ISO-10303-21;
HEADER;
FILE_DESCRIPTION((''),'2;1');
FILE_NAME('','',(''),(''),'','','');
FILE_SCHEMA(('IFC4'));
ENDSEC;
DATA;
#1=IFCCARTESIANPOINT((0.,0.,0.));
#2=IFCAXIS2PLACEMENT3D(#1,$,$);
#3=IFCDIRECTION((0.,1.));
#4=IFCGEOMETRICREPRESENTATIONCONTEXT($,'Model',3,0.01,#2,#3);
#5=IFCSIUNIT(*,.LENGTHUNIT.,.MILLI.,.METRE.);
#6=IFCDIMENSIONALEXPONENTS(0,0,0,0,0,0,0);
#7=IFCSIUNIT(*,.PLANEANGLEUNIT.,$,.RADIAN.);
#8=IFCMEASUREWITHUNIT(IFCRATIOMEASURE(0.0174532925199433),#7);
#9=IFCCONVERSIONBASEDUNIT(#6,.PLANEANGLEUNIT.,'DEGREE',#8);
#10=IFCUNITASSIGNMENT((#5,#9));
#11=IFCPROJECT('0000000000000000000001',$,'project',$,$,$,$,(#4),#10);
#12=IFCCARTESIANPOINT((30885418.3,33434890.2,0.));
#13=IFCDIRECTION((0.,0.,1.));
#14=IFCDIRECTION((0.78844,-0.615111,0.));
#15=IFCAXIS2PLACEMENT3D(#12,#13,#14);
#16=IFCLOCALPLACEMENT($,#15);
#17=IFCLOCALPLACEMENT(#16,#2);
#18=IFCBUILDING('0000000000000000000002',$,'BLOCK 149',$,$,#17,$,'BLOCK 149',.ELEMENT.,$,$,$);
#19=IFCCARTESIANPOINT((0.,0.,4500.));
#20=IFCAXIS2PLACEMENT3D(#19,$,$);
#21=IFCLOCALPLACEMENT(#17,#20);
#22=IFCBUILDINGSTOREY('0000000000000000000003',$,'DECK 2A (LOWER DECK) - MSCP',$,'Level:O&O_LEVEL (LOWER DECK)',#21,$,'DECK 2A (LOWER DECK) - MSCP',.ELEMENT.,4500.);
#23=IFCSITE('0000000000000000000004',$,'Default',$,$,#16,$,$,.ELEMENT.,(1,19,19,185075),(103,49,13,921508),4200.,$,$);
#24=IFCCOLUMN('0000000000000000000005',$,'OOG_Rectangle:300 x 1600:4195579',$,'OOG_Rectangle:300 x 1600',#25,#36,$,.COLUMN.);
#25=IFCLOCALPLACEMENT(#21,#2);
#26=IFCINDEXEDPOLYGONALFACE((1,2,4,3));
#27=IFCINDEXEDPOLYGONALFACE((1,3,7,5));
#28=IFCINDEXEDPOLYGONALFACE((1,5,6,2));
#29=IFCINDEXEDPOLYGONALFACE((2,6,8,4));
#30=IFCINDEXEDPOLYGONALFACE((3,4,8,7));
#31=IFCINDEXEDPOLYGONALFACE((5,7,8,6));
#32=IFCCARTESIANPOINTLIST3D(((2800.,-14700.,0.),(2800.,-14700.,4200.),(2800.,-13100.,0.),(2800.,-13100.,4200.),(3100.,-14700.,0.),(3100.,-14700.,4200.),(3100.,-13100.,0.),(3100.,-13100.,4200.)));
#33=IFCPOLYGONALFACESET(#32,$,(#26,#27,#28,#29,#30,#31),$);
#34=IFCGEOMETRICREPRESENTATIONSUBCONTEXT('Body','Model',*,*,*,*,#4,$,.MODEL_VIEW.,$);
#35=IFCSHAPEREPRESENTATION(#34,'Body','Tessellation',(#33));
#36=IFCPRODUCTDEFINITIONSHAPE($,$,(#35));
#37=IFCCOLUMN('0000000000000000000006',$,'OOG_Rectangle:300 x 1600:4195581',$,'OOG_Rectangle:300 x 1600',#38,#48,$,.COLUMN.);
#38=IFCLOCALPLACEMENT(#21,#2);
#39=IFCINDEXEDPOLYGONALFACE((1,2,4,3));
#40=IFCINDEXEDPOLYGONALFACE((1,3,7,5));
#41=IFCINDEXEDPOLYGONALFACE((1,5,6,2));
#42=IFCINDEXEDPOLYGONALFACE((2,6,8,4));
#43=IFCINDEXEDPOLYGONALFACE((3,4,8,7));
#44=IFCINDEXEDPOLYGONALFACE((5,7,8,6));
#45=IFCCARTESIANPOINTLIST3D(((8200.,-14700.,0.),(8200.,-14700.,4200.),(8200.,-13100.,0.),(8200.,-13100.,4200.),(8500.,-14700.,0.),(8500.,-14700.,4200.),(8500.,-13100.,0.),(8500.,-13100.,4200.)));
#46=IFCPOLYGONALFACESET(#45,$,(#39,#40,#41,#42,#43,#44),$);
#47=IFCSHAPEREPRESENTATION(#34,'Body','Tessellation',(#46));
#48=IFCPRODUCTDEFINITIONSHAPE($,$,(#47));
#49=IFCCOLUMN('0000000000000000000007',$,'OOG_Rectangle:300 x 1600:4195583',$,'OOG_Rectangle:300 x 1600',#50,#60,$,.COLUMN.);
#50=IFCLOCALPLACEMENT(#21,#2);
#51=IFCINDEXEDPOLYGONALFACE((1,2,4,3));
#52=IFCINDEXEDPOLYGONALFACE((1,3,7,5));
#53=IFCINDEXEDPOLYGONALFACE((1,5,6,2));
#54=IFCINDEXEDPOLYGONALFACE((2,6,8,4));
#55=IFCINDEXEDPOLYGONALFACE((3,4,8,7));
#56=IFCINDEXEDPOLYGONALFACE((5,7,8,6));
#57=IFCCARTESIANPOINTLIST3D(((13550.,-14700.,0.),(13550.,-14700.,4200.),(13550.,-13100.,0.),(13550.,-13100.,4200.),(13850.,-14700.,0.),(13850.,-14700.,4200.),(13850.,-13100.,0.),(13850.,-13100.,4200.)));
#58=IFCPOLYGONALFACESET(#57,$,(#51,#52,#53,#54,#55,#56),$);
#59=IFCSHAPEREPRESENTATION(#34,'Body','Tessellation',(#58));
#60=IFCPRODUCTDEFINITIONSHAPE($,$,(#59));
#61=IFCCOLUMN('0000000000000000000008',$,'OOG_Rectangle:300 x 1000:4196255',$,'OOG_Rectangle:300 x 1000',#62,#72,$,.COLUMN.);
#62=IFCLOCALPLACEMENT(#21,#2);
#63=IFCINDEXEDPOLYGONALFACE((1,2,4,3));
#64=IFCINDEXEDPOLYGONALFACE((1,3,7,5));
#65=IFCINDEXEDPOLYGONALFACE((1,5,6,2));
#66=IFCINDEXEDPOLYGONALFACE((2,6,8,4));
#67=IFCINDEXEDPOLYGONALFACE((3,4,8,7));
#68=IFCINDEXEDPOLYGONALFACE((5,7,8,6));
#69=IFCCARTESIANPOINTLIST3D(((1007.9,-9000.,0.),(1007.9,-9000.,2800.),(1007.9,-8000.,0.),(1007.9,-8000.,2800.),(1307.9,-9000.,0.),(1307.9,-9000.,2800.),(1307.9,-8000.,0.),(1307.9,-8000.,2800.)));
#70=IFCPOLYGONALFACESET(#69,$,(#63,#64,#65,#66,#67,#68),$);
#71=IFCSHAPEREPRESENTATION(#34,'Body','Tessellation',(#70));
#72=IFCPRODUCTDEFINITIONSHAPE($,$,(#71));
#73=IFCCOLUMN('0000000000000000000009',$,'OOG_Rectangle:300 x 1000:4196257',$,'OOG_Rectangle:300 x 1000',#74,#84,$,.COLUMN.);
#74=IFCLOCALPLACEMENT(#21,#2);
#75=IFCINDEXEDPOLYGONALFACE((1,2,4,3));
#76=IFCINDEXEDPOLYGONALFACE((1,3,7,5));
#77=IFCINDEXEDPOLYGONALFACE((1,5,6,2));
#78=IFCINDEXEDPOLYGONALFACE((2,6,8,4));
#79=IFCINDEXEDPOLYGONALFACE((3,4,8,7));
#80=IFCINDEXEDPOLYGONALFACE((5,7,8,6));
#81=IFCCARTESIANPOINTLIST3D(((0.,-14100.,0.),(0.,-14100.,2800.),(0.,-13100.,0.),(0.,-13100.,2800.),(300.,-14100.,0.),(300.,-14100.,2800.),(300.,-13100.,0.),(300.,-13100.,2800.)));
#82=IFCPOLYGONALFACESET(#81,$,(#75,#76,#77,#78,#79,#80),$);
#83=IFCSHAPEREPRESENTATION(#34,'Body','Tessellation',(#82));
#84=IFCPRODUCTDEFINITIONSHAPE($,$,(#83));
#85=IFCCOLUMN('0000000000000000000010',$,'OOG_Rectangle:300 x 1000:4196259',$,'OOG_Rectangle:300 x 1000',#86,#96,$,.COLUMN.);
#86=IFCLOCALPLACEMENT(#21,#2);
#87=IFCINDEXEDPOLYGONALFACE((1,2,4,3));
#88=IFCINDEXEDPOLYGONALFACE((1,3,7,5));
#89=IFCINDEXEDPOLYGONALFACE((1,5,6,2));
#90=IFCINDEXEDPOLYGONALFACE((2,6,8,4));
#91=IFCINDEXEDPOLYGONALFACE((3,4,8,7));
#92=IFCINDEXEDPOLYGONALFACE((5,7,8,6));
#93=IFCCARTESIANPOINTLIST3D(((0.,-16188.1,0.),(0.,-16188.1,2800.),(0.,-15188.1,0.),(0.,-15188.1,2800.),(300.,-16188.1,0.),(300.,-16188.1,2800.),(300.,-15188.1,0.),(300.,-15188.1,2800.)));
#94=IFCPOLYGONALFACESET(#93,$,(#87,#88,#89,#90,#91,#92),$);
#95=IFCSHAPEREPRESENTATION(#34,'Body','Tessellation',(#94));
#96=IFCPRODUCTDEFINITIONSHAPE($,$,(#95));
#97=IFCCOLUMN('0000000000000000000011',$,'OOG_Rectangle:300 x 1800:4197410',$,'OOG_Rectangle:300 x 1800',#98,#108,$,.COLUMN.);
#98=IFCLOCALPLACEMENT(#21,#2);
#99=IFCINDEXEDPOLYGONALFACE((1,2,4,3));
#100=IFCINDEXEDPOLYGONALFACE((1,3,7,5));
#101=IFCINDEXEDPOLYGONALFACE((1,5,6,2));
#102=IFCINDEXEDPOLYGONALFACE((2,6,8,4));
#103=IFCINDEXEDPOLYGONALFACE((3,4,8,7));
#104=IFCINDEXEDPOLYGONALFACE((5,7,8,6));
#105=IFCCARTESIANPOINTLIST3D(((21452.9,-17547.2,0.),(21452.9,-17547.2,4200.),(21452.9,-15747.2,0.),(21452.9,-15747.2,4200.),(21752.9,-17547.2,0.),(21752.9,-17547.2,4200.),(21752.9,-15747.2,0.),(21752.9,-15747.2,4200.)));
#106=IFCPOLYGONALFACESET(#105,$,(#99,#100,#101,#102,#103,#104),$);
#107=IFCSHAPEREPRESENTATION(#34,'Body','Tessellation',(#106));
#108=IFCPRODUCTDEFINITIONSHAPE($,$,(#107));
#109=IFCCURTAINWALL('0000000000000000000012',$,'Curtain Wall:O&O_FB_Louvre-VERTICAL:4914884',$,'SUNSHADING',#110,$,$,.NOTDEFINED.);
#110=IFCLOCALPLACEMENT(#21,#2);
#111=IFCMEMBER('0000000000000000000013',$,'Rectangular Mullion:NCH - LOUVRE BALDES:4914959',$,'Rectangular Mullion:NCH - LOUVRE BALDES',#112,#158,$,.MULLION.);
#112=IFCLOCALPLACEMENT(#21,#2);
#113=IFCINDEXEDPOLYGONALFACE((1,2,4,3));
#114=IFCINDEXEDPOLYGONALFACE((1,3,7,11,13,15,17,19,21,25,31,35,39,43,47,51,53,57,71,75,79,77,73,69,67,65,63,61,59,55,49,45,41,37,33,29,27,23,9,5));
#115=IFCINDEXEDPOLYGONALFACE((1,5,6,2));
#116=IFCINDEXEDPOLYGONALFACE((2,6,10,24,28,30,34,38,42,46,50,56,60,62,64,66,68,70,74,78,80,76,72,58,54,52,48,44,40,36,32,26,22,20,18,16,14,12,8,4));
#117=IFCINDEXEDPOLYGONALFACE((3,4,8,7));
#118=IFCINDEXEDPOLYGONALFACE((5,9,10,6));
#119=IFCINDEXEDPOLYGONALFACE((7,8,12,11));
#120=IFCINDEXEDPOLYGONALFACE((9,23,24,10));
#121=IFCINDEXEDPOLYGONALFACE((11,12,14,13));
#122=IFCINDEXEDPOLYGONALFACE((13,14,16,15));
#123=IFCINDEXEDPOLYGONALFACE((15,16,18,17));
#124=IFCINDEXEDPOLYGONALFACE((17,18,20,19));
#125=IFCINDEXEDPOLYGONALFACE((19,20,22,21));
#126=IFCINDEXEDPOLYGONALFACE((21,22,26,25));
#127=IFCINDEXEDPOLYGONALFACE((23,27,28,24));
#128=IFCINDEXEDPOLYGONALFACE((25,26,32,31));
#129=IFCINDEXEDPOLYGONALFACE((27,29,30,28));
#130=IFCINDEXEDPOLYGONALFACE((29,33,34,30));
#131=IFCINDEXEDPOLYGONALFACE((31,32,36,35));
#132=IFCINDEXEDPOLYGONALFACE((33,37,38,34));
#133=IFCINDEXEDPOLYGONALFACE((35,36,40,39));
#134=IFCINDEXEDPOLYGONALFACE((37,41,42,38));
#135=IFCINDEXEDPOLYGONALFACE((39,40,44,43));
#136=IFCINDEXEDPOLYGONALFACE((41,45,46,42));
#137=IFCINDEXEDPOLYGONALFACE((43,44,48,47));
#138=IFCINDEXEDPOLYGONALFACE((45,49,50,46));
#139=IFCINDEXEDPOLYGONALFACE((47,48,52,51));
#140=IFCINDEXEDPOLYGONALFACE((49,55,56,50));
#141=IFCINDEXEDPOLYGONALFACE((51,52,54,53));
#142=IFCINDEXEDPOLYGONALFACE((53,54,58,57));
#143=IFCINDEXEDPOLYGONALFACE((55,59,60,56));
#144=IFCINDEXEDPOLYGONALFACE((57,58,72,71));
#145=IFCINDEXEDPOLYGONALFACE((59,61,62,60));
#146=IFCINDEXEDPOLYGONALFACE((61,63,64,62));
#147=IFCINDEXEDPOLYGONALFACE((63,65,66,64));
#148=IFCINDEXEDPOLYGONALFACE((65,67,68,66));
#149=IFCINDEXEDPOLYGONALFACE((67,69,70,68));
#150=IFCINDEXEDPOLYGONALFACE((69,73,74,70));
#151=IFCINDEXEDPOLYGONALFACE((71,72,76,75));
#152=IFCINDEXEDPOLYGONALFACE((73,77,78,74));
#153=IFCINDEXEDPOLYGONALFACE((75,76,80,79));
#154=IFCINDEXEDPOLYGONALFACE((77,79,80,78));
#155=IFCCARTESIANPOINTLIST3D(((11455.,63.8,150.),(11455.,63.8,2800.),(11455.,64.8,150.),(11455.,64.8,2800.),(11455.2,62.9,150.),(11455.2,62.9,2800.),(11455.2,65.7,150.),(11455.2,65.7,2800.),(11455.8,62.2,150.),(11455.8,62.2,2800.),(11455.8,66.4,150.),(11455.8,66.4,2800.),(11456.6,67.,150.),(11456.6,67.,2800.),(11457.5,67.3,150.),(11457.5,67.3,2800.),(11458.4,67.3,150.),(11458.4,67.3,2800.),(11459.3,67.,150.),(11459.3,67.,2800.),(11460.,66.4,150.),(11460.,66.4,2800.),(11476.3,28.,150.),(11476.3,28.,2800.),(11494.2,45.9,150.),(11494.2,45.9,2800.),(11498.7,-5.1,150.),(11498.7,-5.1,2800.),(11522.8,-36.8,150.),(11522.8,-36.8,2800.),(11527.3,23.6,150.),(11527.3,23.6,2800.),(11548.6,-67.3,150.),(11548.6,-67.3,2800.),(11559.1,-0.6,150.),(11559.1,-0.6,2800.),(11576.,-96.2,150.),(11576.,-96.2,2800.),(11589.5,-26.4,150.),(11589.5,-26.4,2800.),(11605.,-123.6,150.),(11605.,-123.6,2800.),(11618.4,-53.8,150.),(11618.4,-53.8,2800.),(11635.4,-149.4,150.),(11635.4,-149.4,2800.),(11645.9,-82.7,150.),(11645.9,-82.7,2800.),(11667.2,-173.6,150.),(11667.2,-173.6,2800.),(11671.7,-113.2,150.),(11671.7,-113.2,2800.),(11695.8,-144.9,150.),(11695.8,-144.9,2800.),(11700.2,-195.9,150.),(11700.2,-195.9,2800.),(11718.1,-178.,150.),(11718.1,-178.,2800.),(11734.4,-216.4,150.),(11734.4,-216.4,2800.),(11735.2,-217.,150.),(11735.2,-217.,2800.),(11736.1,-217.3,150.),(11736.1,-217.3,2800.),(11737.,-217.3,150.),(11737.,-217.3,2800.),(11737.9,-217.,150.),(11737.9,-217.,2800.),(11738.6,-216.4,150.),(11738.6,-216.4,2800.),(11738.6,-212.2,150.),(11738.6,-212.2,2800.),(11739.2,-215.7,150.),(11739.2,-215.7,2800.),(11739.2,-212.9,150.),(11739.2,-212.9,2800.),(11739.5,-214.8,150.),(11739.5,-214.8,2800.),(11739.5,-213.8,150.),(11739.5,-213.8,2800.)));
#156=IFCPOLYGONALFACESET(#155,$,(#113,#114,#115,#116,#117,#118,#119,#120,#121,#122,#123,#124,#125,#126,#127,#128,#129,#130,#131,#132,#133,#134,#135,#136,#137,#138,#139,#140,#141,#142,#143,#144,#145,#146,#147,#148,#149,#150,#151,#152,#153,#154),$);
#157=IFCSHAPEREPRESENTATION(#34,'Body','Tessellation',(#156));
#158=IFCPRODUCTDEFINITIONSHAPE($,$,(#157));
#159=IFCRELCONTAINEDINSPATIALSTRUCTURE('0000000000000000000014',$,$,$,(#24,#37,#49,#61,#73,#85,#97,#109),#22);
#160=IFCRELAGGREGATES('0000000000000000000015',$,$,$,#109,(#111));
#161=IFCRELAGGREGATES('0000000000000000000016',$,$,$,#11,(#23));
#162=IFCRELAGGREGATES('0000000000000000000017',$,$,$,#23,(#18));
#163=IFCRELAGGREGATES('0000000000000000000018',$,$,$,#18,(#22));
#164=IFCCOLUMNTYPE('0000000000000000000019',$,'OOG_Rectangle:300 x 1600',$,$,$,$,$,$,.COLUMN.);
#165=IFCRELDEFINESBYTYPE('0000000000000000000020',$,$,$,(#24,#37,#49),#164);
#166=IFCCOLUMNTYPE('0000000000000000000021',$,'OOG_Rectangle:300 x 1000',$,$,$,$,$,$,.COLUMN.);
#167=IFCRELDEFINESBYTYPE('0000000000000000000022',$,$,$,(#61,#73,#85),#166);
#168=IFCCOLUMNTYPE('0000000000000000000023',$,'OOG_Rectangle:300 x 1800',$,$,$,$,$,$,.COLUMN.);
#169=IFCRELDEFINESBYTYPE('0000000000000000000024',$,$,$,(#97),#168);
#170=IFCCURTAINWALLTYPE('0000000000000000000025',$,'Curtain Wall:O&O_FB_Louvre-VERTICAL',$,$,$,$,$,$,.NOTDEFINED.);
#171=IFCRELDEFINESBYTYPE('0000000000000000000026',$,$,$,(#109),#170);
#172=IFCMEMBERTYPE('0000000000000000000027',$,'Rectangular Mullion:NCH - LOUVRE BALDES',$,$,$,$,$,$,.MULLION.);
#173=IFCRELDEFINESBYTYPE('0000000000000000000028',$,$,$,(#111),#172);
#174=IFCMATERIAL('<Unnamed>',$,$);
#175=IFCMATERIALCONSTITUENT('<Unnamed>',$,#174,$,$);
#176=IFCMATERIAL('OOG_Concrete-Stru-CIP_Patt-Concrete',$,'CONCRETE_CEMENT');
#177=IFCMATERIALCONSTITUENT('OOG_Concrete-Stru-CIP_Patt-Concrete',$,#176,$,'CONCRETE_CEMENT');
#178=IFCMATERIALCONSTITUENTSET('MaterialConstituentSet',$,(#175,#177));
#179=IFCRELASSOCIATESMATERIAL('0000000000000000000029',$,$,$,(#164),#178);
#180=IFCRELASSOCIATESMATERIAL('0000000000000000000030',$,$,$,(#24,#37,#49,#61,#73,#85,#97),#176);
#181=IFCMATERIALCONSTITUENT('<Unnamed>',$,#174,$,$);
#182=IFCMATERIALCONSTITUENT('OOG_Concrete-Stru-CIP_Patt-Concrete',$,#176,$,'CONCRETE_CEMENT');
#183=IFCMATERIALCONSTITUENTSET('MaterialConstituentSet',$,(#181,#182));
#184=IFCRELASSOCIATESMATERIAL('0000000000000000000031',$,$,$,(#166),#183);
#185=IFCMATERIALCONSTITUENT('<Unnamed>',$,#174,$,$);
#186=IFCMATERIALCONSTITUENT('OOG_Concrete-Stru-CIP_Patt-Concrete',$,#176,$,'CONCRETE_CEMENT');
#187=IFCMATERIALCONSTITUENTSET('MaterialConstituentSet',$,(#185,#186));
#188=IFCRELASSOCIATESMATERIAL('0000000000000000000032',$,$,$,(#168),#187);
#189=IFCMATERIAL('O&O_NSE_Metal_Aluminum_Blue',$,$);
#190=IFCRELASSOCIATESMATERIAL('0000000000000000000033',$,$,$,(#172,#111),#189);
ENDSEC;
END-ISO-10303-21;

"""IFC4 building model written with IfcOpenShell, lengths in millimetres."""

from ifc_helpers import new_model, entity, si_unit, converted_unit, direction, frame, origin, place, context, subcontext, project, spatial, indexed_curve, outline, extrude, source, transform, mapped, material, constituent, constituent_set, type_object, type_shapes, element, aggregate, save


model = new_model("IFC4")

# Units and contexts
model_context = context("Model", 3, precision=0.01, world=origin(), true_north=direction((0.0, 1.0)))
body_context = subcontext(model_context, "Body", "Model", "MODEL_VIEW")
ifc_project = project(units=[si_unit("LENGTHUNIT", "METRE", prefix="MILLI"), converted_unit("PLANEANGLEUNIT", "DEGREE", entity("IfcRatioMeasure", 0.0174532925199433), si_unit("PLANEANGLEUNIT", "RADIAN"), dimensions=[0, 0, 0, 0, 0, 0, 0])], contexts=[model_context])

# Site, building, storey
site_placement = place(None, frame((30885418.3, 33434890.2, 0.0), z_axis=(0.0, 0.0, 1.0), x_axis=(0.78844, -0.615111, 0.0)))
site = spatial("IfcSite", under=ifc_project, at=site_placement, Name="Default", CompositionType="ELEMENT", RefLatitude=(1, 19, 19, 185075), RefLongitude=(103, 49, 13, 921508), RefElevation=4200.0)
building_placement = place(site_placement, origin())
building = spatial("IfcBuilding", under=site, at=building_placement, Name="BLOCK 149", LongName="BLOCK 149", CompositionType="ELEMENT")
storey_placement = place(building_placement, frame((0.0, 0.0, 4500.0)))
storey = spatial("IfcBuildingStorey", under=building, at=storey_placement, Name="DECK 2A (LOWER DECK) - MSCP", ObjectType="Level:O&O_LEVEL (LOWER DECK)", LongName="DECK 2A (LOWER DECK) - MSCP", CompositionType="ELEMENT", Elevation=4500.0)

# Columns
ifc_material_1 = material(Name="OOG_Concrete-Stru-CIP_Patt-Concrete", Category="CONCRETE_CEMENT")
ifc_material_2 = material(Name="<Unnamed>")
ifc_constituent_1 = constituent(ifc_material_2, Name="<Unnamed>")
ifc_constituent_2 = constituent(ifc_material_1, Name="OOG_Concrete-Stru-CIP_Patt-Concrete", Category="CONCRETE_CEMENT")
ifc_constituent_set_1 = constituent_set(constituents=[ifc_constituent_1, ifc_constituent_2], Name="MaterialConstituentSet")
column_type_1 = type_object("IfcColumnType", Name="OOG_Rectangle:300 x 1600", PredefinedType="COLUMN", material=ifc_constituent_set_1)
shared_shape_1 = source(origin(), body_context, "Body", "SweptSolid", [
    extrude(outline(indexed_curve([(-800.0, -150.0), (800.0, -150.0), (800.0, 150.0), (-800.0, 150.0), (-800.0, -150.0)], self_intersect=False)), frame((0.0, 0.0, 4500.0), z_axis=(0.0, 0.0, 1.0), x_axis=(0.0, -1.0, 0.0)), (0.0, 0.0, 1.0), 4200.0),
])
type_shapes(column_type_1, [shared_shape_1])
for number, where, name in (
    (1, (2950.0, -13900.0, -4500.0), "OOG_Rectangle:300 x 1600:4195579"),
    (2, (8350.0, -13900.0, -4500.0), "OOG_Rectangle:300 x 1600:4195581"),
    (3, (13700.0, -13900.0, -4500.0), "OOG_Rectangle:300 x 1600:4195583"),
):
    element("IfcColumn", number, at=place(storey_placement, frame(where)), inside=storey, type_object=column_type_1, material=ifc_material_1, Name=name, ObjectType="OOG_Rectangle:300 x 1600", PredefinedType="COLUMN", context=body_context, shape_type="MappedRepresentation", body=[
        mapped(shared_shape_1, transform((0.0, 0.0, 0.0), scale=1.0)),
    ])
ifc_constituent_3 = constituent(ifc_material_2, Name="<Unnamed>")
ifc_constituent_4 = constituent(ifc_material_1, Name="OOG_Concrete-Stru-CIP_Patt-Concrete", Category="CONCRETE_CEMENT")
ifc_constituent_set_2 = constituent_set(constituents=[ifc_constituent_3, ifc_constituent_4], Name="MaterialConstituentSet")
column_type_2 = type_object("IfcColumnType", Name="OOG_Rectangle:300 x 1000", PredefinedType="COLUMN", material=ifc_constituent_set_2)
shared_shape_2 = source(origin(), body_context, "Body", "SweptSolid", [
    extrude(outline(indexed_curve([(-500.0, -150.0), (500.0, -150.0), (500.0, 150.0), (-500.0, 150.0), (-500.0, -150.0)], self_intersect=False)), frame((0.0, 0.0, 4500.0), z_axis=(0.0, 0.0, 1.0), x_axis=(0.0, -1.0, 0.0)), (0.0, 0.0, 1.0), 2800.0),
])
type_shapes(column_type_2, [shared_shape_2])
for number, where, name in (
    (4, (1157.9, -8500.0, -4500.0), "OOG_Rectangle:300 x 1000:4196255"),
    (5, (150.0, -13600.0, -4500.0), "OOG_Rectangle:300 x 1000:4196257"),
    (6, (150.0, -15688.1, -4500.0), "OOG_Rectangle:300 x 1000:4196259"),
):
    element("IfcColumn", number, at=place(storey_placement, frame(where)), inside=storey, type_object=column_type_2, material=ifc_material_1, Name=name, ObjectType="OOG_Rectangle:300 x 1000", PredefinedType="COLUMN", context=body_context, shape_type="MappedRepresentation", body=[
        mapped(shared_shape_2, transform((0.0, 0.0, 0.0), scale=1.0)),
    ])
ifc_constituent_5 = constituent(ifc_material_2, Name="<Unnamed>")
ifc_constituent_6 = constituent(ifc_material_1, Name="OOG_Concrete-Stru-CIP_Patt-Concrete", Category="CONCRETE_CEMENT")
ifc_constituent_set_3 = constituent_set(constituents=[ifc_constituent_5, ifc_constituent_6], Name="MaterialConstituentSet")
column_type_3 = type_object("IfcColumnType", Name="OOG_Rectangle:300 x 1800", PredefinedType="COLUMN", material=ifc_constituent_set_3)
shared_shape_3 = source(origin(), body_context, "Body", "SweptSolid", [
    extrude(outline(indexed_curve([(-900.0, -150.0), (900.0, -150.0), (900.0, 150.0), (-900.0, 150.0), (-900.0, -150.0)], self_intersect=False)), frame((0.0, 0.0, 4500.0), z_axis=(0.0, 0.0, 1.0), x_axis=(0.0, -1.0, 0.0)), (0.0, 0.0, 1.0), 4200.0),
])
type_shapes(column_type_3, [shared_shape_3])
column_placement = place(storey_placement, frame((21602.9, -16647.2, -4500.0)))
element("IfcColumn", 7, at=column_placement, inside=storey, type_object=column_type_3, material=ifc_material_1, Name="OOG_Rectangle:300 x 1800:4197410", ObjectType="OOG_Rectangle:300 x 1800", PredefinedType="COLUMN", context=body_context, shape_type="MappedRepresentation", body=[
    mapped(shared_shape_3, transform((0.0, 0.0, 0.0), scale=1.0)),
])

# Curtain wall, member
curtain_wall_type = type_object("IfcCurtainWallType", Name="Curtain Wall:O&O_FB_Louvre-VERTICAL", PredefinedType="NOTDEFINED")
curtain_wall_placement = place(storey_placement, frame((0.0, 0.0, -4500.0)))
curtain_wall = element("IfcCurtainWall", 8, at=curtain_wall_placement, inside=storey, type_object=curtain_wall_type, Name="Curtain Wall:O&O_FB_Louvre-VERTICAL:4914884", ObjectType="SUNSHADING", PredefinedType="NOTDEFINED")
ifc_material_3 = material(Name="O&O_NSE_Metal_Aluminum_Blue")
member_type_1 = type_object("IfcMemberType", Name="Rectangular Mullion:NCH - LOUVRE BALDES", PredefinedType="MULLION", material=ifc_material_3)
shared_shape_4 = source(origin(), body_context, "Body", "SweptSolid", [
    extrude(outline(indexed_curve([(55.9, -188.9), (54.8, -149.1), (51.6, -109.3), (46.1, -69.8), (38.6, -30.6), (28.9, 8.1), (17.1, 46.2), (3.3, 83.6), (-12.6, 120.2), (-30.4, 155.9), (-50.1, 190.5), (-50.5, 191.4), (-51.1, 192.1), (-52.0, 192.5), (-52.9, 192.7), (-53.8, 192.6), (-54.7, 192.2), (-55.4, 191.6), (-55.8, 190.8), (-56.0, 189.9), (-55.9, 188.9), (-54.8, 149.1), (-51.6, 109.3), (-46.1, 69.8), (-38.6, 30.6), (-28.9, -8.1), (-17.1, -46.2), (-3.3, -83.6), (12.6, -120.2), (30.4, -155.9), (50.1, -190.5), (50.5, -191.4), (51.1, -192.1), (52.0, -192.5), (52.9, -192.7), (53.8, -192.6), (54.7, -192.2), (55.4, -191.6), (55.8, -190.8), (56.0, -189.9), (55.9, -188.9)], self_intersect=False)), frame((0.0, 0.0, -2650.0), z_axis=(0.0, 0.0, 1.0), x_axis=(0.490779, -0.871284, 0.0)), (0.0, 0.0, 1.0), 2650.0),
])
type_shapes(member_type_1, [shared_shape_4])
member_1_placement = place(storey_placement, frame((11597.2, -75.0, 150.0), z_axis=(0.0, 0.0, -1.0), x_axis=(-1.0, 0.0, 0.0)))
member_1 = element("IfcMember", 9, at=member_1_placement, type_object=member_type_1, material=ifc_material_3, Name="Rectangular Mullion:NCH - LOUVRE BALDES:4914959", ObjectType="Rectangular Mullion:NCH - LOUVRE BALDES", PredefinedType="MULLION", context=body_context, shape_type="MappedRepresentation", body=[
    mapped(shared_shape_4, transform((0.0, 0.0, 0.0), scale=1.0)),
])
aggregate(curtain_wall, [member_1])

save(model, "model.ifc")
